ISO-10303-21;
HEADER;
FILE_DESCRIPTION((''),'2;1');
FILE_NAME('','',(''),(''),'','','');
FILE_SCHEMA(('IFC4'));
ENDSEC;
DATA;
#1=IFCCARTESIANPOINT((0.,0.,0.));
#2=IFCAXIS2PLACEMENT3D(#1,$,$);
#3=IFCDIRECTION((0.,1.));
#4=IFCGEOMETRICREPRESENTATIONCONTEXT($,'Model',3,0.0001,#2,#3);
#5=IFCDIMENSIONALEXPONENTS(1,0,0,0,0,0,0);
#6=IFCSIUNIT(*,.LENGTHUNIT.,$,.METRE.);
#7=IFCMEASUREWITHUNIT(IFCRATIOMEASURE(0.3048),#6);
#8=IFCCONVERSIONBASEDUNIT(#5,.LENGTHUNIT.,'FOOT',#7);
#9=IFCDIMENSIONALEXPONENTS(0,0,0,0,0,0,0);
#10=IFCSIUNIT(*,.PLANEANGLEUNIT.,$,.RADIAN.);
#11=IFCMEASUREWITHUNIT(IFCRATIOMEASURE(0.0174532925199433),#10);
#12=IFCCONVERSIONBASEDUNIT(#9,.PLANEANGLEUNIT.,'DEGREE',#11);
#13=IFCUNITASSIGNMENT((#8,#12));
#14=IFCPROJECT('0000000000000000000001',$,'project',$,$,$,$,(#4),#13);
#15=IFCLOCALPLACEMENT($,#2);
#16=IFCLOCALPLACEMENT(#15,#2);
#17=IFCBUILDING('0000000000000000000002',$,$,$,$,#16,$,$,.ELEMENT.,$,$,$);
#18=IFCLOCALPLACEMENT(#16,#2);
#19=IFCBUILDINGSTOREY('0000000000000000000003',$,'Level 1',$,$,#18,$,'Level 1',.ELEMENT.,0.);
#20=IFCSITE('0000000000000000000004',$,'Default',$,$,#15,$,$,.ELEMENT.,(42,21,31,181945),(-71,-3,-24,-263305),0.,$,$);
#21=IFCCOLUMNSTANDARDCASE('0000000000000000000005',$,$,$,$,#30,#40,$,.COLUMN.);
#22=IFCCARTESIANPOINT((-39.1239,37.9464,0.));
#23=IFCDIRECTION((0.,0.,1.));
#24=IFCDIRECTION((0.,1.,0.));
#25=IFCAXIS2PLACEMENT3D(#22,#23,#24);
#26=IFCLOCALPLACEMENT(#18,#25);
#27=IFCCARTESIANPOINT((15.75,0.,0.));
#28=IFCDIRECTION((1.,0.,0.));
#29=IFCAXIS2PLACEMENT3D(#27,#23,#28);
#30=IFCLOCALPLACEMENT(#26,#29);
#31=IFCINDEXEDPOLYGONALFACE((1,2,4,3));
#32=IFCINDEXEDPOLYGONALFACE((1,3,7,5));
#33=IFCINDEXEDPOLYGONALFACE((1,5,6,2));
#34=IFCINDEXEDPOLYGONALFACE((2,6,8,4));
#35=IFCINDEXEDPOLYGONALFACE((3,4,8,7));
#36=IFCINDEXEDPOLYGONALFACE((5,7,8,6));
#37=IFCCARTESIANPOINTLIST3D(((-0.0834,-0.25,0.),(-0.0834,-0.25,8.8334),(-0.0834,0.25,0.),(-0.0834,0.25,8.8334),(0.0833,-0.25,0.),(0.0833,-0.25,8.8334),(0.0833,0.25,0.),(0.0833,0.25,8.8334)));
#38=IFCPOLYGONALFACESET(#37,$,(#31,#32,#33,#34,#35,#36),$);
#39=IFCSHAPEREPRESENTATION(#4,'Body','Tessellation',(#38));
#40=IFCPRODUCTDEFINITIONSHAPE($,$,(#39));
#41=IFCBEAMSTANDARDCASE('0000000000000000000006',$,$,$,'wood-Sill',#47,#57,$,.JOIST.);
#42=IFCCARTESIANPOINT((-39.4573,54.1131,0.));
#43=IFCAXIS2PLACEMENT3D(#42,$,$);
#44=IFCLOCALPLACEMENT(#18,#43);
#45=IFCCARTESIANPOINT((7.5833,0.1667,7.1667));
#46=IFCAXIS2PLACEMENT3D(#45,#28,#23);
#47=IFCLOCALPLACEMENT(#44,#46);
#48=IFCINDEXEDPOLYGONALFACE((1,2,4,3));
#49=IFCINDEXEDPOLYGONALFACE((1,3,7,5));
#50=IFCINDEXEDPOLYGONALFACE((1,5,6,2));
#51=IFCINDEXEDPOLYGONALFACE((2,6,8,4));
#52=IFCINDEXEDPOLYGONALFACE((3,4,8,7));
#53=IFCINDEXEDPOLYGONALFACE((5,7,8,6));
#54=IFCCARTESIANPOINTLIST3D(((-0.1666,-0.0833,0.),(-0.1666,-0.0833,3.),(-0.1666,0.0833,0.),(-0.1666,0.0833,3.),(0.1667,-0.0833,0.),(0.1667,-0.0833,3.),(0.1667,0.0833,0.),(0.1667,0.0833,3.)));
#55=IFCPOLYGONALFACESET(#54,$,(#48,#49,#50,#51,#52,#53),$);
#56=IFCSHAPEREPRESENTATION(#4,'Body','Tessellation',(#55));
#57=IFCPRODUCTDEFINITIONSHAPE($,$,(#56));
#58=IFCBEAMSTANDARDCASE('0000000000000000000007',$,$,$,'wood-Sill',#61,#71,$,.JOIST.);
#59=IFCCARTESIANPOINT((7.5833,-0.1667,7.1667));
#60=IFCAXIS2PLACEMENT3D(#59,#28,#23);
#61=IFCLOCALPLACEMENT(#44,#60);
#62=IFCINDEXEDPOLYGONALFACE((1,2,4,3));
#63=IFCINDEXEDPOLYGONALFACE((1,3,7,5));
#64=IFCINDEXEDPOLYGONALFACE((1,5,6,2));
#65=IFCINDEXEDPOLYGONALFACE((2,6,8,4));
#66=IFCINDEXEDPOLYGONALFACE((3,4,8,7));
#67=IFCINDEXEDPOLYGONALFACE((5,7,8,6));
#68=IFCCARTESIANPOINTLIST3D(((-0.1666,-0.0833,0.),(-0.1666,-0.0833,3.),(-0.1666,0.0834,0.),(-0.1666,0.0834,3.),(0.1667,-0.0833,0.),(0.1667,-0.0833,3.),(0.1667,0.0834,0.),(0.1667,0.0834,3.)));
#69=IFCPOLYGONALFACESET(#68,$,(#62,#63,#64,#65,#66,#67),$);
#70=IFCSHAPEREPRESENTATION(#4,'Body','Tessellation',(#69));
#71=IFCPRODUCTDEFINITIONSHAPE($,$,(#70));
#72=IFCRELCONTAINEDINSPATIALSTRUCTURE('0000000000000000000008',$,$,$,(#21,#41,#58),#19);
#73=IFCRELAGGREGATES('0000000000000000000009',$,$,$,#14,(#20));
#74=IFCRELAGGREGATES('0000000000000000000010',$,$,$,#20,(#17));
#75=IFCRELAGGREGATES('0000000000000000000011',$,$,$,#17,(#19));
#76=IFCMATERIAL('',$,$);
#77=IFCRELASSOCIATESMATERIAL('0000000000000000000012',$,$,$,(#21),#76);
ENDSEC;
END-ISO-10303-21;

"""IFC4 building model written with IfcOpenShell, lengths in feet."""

from ifc_helpers import new_model, entity, si_unit, converted_unit, direction, frame, origin, origin_with_axes, place, context, project, spatial, rectangle, extrude, material, element, save


model = new_model("IFC4")

# Units and contexts
model_context = context("Model", 3, precision=0.0001, world=origin(), true_north=direction((0.0, 1.0)))
ifc_project = project(units=[converted_unit("LENGTHUNIT", "FOOT", entity("IfcRatioMeasure", 0.3048), si_unit("LENGTHUNIT", "METRE"), dimensions=[1, 0, 0, 0, 0, 0, 0]), converted_unit("PLANEANGLEUNIT", "DEGREE", entity("IfcRatioMeasure", 0.0174532925199433), si_unit("PLANEANGLEUNIT", "RADIAN"), dimensions=[0, 0, 0, 0, 0, 0, 0])], contexts=[model_context])

# Site, building, storey
site_placement = place(None, origin())
site = spatial("IfcSite", under=ifc_project, at=site_placement, Name="Default", CompositionType="ELEMENT", RefLatitude=(42, 21, 31, 181945), RefLongitude=(-71, -3, -24, -263305), RefElevation=0.0)
building_placement = place(site_placement, origin())
building = spatial("IfcBuilding", under=site, at=building_placement, CompositionType="ELEMENT")
storey_placement = place(building_placement, origin())
storey = spatial("IfcBuildingStorey", under=building, at=storey_placement, Name="Level 1", LongName="Level 1", CompositionType="ELEMENT", Elevation=0.0)

# Column
placement_1 = place(storey_placement, frame((-39.4573, 54.1131, 0.0)))
ifc_material_1 = material(Name="")
placement_2 = place(storey_placement, frame((-39.1239, 37.9464, 0.0), z_axis=(0.0, 0.0, 1.0), x_axis=(0.0, 1.0, 0.0)))
for number, where, z_axis, x_axis in (
    (1, (15.75, 0.0, 0.0), (0.0, 0.0, 1.0), (1.0, 0.0, 0.0)),
):
    element("IfcColumnStandardCase", number, at=place(placement_2, frame(where, z_axis=z_axis, x_axis=x_axis)), inside=storey, material=ifc_material_1, PredefinedType="COLUMN", context=model_context, shape_type="SweptSolid", body=[
        extrude(rectangle(XDim=0.1667, YDim=0.5), origin(), (0.0, 0.0, 1.0), 8.8334),
    ])

# Beams
for number, where, z_axis, x_axis in (
    (2, (7.5833, 0.1667, 7.1667), (1.0, 0.0, 0.0), (0.0, 0.0, 1.0)),
    (3, (7.5833, -0.1667, 7.1667), (1.0, 0.0, 0.0), (0.0, 0.0, 1.0)),
):
    element("IfcBeamStandardCase", number, at=place(placement_1, frame(where, z_axis=z_axis, x_axis=x_axis)), inside=storey, ObjectType="wood-Sill", PredefinedType="JOIST", context=model_context, shape_type="SweptSolid", body=[
        extrude(rectangle(XDim=0.3333, YDim=0.1667), origin_with_axes(), (0.0, 0.0, 1.0), 3.0),
    ])

save(model, "model.ifc")
